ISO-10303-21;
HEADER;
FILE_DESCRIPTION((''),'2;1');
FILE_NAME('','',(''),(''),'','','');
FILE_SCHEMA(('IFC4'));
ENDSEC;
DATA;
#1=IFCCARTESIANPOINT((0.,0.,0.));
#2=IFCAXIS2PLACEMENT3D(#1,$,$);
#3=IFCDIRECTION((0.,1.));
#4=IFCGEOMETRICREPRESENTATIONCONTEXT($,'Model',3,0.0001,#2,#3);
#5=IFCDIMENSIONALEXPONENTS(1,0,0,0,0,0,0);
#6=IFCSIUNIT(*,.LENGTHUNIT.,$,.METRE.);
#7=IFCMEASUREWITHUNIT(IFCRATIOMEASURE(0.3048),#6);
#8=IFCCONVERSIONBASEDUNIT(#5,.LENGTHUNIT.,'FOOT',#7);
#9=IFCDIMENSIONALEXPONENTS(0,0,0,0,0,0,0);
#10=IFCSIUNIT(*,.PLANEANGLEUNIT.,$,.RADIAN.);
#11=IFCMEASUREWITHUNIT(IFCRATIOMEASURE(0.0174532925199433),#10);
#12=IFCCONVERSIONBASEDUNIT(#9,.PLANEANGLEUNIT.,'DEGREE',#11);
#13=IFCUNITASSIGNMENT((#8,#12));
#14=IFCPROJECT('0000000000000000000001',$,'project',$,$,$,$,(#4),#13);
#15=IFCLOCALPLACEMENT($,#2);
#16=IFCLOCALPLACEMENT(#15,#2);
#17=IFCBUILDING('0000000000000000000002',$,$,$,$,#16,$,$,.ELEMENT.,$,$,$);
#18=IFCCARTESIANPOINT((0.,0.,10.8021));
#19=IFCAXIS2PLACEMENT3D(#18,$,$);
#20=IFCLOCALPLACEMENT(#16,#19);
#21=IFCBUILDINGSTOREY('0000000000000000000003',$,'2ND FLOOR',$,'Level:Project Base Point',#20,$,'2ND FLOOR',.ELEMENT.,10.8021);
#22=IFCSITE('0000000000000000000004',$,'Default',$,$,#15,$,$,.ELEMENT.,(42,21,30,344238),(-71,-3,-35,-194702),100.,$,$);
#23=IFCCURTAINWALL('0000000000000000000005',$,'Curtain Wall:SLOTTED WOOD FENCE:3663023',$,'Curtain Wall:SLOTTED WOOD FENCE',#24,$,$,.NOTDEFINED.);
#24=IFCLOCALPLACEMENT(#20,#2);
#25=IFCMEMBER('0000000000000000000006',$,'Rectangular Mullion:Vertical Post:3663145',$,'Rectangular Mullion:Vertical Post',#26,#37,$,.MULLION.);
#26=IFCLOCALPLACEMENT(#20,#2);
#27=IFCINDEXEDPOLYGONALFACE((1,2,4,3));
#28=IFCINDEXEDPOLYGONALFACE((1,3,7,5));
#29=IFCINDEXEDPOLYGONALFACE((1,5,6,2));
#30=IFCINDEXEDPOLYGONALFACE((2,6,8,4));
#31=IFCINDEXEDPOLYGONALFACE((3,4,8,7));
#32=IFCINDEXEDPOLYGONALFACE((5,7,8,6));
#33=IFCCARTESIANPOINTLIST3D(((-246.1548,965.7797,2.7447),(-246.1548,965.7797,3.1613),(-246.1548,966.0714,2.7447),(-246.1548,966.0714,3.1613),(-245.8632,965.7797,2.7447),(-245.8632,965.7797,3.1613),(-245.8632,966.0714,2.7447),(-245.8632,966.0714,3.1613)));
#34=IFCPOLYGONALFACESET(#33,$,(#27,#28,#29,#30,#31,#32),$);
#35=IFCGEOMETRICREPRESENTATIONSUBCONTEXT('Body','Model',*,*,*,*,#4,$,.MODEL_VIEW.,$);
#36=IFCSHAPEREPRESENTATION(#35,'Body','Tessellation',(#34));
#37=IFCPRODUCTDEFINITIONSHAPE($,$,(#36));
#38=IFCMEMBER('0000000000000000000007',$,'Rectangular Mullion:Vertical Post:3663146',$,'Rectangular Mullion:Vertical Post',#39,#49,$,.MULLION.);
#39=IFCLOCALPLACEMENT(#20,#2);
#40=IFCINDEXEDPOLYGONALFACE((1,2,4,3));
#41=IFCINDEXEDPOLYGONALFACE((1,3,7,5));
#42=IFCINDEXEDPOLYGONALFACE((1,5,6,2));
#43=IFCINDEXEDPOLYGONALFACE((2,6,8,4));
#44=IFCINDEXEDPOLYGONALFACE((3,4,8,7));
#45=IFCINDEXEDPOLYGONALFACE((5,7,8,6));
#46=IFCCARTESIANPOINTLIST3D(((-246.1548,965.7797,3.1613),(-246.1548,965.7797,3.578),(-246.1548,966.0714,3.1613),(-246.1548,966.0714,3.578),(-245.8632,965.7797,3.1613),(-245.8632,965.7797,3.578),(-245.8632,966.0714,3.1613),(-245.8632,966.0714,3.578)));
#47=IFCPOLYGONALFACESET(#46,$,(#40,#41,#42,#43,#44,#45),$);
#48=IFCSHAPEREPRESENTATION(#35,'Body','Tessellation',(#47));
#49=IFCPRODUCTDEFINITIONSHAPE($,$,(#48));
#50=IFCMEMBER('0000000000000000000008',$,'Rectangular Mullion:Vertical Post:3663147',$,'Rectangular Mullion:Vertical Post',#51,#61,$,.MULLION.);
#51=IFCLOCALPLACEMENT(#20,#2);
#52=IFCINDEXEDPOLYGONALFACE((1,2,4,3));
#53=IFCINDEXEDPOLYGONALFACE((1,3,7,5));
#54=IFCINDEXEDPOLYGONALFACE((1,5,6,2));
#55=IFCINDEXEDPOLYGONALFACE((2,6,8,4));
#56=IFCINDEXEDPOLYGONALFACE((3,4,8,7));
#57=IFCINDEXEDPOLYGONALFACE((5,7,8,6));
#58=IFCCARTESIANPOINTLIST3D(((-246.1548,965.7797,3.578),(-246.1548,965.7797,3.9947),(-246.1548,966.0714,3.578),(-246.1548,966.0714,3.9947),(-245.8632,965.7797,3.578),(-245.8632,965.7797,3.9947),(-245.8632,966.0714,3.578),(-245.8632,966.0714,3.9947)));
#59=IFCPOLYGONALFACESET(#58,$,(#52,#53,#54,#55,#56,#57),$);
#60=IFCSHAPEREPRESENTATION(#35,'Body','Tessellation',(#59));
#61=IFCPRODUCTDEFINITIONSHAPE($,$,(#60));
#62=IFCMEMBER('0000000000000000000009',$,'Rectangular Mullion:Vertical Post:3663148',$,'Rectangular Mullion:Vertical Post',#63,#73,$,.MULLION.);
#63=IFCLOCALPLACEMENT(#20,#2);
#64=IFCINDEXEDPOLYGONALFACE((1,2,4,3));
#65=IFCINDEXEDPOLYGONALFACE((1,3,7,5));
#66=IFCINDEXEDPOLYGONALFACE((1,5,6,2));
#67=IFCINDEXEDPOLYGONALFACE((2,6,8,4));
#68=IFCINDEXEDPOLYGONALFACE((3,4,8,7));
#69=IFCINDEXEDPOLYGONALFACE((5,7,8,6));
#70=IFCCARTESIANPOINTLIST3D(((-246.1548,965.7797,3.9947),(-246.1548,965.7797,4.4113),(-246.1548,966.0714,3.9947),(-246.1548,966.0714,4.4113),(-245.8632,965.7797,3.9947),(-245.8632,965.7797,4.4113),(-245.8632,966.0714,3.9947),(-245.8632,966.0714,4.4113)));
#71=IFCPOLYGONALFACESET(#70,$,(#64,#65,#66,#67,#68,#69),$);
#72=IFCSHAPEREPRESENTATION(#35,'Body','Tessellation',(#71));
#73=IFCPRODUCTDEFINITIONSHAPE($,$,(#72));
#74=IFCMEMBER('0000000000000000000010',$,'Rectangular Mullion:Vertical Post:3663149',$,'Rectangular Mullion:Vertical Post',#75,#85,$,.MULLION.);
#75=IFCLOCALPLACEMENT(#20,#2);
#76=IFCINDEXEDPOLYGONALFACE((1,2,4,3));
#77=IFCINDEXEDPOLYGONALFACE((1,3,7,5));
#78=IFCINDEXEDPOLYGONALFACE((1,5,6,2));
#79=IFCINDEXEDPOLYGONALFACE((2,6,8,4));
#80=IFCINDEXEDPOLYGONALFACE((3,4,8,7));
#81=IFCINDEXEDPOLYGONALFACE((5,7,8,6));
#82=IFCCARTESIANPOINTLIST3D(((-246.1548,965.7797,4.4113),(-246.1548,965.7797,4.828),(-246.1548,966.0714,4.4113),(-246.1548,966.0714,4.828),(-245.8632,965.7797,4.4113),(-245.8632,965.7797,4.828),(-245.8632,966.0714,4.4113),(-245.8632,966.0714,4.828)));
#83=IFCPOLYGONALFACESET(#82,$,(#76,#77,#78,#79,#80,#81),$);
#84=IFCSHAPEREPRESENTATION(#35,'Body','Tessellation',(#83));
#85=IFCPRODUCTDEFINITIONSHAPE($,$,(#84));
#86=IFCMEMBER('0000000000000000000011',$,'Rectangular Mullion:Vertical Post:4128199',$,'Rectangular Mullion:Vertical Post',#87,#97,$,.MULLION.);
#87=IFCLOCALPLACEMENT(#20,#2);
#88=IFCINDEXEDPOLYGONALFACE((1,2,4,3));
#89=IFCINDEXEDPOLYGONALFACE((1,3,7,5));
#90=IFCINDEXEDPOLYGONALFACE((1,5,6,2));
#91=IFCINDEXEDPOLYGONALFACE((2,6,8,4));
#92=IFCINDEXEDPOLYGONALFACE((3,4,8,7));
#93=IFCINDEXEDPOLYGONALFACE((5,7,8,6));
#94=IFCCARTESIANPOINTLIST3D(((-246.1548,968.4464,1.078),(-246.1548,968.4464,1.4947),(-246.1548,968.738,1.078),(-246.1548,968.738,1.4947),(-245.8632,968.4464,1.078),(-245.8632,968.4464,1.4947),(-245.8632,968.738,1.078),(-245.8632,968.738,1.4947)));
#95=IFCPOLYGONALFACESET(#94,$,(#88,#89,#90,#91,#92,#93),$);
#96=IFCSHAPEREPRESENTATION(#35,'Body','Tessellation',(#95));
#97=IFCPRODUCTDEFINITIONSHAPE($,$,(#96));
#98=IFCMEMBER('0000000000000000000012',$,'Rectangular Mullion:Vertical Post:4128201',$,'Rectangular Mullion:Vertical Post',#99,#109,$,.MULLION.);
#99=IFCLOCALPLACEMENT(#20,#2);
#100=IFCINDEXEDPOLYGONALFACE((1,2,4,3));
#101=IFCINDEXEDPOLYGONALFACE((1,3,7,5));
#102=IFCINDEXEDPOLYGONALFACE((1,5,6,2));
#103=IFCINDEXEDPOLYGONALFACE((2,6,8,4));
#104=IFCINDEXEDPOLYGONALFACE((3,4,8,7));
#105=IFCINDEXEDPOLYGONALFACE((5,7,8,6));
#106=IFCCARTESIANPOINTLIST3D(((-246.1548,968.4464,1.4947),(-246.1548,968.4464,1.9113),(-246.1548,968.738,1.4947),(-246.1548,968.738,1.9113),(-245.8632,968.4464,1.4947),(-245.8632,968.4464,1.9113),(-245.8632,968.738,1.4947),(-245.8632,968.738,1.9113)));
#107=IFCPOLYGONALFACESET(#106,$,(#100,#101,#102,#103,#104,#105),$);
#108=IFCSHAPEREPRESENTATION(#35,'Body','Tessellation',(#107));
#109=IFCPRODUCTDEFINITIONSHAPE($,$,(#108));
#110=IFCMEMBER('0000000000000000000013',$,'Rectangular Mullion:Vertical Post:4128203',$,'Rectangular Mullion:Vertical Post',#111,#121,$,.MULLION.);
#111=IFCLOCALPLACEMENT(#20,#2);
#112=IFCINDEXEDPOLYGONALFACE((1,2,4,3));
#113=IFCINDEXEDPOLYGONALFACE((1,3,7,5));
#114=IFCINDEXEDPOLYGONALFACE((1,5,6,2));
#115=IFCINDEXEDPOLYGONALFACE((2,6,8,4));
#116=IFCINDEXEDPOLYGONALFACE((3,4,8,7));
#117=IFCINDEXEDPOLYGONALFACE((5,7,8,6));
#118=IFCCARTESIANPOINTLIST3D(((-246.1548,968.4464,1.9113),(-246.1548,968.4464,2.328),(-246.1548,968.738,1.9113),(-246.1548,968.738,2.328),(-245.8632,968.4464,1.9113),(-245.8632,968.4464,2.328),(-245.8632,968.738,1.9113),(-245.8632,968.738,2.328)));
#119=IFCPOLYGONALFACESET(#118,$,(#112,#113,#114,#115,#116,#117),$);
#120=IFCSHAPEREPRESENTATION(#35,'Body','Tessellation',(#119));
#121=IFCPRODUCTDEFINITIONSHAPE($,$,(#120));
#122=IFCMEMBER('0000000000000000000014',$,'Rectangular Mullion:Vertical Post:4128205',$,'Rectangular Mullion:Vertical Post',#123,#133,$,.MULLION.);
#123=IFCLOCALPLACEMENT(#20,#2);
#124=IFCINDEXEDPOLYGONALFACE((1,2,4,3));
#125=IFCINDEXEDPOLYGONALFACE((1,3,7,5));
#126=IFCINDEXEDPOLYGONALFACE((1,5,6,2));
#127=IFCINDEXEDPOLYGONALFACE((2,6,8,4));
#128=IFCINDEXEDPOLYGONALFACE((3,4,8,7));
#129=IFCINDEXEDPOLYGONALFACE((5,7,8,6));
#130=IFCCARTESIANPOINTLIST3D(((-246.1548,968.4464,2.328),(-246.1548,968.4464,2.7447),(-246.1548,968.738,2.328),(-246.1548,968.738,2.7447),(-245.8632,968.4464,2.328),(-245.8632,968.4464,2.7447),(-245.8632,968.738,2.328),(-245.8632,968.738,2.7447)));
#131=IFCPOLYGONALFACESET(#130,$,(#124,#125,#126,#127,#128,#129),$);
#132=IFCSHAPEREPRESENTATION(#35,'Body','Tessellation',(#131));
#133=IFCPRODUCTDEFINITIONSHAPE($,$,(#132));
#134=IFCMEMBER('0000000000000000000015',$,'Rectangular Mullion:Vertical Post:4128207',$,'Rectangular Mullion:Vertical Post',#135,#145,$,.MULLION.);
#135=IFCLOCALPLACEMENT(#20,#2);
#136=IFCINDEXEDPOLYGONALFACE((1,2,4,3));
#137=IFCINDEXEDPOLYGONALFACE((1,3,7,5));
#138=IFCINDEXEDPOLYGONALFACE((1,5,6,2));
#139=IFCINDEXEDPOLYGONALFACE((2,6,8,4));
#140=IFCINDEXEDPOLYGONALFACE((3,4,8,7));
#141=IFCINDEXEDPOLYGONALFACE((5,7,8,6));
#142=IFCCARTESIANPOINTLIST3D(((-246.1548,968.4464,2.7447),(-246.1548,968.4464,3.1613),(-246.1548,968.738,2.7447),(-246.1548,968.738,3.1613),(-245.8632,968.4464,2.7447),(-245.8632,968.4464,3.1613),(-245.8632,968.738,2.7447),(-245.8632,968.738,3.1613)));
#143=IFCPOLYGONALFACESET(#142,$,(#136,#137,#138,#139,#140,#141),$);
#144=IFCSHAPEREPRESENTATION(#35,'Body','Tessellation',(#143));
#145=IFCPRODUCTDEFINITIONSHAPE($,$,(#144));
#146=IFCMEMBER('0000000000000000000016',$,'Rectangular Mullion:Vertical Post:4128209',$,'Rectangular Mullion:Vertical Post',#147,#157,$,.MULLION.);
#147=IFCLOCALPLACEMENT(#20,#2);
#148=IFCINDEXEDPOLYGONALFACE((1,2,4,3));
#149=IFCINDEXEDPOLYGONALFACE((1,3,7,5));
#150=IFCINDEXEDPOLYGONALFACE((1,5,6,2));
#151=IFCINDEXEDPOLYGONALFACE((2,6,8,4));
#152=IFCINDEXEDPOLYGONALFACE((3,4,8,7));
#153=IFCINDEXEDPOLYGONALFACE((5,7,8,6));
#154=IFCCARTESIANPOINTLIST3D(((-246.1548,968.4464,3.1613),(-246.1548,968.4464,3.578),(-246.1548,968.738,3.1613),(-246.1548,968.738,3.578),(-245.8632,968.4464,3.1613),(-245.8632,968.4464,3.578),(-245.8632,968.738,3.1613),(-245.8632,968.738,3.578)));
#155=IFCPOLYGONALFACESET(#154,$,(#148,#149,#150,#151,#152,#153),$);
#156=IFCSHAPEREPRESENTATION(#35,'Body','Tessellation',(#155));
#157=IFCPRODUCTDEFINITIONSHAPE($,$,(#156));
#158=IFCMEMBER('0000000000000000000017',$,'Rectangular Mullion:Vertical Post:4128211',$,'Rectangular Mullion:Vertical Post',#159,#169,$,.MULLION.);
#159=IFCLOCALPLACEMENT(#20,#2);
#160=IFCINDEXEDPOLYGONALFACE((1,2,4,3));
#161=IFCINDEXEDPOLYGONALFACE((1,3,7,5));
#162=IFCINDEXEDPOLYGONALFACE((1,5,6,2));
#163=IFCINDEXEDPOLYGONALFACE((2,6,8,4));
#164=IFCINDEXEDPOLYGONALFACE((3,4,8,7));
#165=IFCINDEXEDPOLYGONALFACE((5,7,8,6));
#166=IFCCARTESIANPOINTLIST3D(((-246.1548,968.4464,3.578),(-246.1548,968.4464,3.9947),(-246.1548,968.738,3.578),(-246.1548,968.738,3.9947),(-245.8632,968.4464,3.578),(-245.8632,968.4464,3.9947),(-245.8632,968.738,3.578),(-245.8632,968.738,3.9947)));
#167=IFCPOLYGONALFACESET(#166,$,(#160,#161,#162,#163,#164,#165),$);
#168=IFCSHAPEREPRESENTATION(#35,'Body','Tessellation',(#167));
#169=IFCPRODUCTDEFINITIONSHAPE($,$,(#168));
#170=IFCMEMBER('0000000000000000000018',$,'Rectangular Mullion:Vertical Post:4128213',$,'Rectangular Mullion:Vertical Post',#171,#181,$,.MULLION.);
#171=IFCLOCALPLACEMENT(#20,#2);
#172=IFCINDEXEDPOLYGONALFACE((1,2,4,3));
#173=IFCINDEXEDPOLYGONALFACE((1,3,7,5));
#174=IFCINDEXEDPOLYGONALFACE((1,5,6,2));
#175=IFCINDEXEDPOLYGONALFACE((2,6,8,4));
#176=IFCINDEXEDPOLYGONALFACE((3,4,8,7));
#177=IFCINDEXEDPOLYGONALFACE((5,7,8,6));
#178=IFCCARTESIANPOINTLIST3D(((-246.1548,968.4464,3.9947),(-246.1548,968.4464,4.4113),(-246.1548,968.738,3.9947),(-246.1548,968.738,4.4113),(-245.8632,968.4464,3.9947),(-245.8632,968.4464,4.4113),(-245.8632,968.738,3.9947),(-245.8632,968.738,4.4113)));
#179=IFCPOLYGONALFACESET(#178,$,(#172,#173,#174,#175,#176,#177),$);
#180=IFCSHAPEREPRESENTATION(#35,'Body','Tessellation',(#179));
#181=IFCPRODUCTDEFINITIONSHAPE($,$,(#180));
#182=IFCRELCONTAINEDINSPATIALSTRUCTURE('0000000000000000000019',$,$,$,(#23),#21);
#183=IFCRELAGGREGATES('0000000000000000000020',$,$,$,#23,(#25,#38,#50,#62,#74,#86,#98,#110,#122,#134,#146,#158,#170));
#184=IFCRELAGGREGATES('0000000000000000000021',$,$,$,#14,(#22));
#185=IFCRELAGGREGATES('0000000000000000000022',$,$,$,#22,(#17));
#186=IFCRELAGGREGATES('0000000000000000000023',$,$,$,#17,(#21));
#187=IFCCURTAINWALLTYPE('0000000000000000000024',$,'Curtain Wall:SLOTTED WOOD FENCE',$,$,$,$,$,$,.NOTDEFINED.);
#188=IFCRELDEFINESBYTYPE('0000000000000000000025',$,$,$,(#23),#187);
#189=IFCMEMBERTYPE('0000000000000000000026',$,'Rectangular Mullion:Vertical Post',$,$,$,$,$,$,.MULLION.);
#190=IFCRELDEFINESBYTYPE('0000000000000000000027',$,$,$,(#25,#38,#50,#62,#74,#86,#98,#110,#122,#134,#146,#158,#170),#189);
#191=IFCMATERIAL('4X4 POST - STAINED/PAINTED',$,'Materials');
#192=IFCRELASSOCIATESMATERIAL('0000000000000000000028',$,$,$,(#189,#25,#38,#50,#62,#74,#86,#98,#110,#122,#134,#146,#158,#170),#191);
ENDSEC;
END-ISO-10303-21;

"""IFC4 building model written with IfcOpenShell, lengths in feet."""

from ifc_helpers import new_model, entity, si_unit, converted_unit, direction, frame, origin, origin_2d_with_axis, place, context, subcontext, project, spatial, rectangle, extrude, source, transform, mapped, material, material_profile, profile_set, profile_usage, type_object, type_shapes, element, aggregate, save


model = new_model("IFC4")

# Units and contexts
model_context = context("Model", 3, precision=0.0001, world=origin(), true_north=direction((0.0, 1.0)))
body_context = subcontext(model_context, "Body", "Model", "MODEL_VIEW")
ifc_project = project(units=[converted_unit("LENGTHUNIT", "FOOT", entity("IfcRatioMeasure", 0.3048), si_unit("LENGTHUNIT", "METRE"), dimensions=[1, 0, 0, 0, 0, 0, 0]), converted_unit("PLANEANGLEUNIT", "DEGREE", entity("IfcRatioMeasure", 0.0174532925199433), si_unit("PLANEANGLEUNIT", "RADIAN"), dimensions=[0, 0, 0, 0, 0, 0, 0])], contexts=[model_context])

# Site, building, storey
site_placement = place(None, origin())
site = spatial("IfcSite", under=ifc_project, at=site_placement, Name="Default", CompositionType="ELEMENT", RefLatitude=(42, 21, 30, 344238), RefLongitude=(-71, -3, -35, -194702), RefElevation=100.0)
building_placement = place(site_placement, origin())
building = spatial("IfcBuilding", under=site, at=building_placement, CompositionType="ELEMENT")
storey_placement = place(building_placement, frame((0.0, 0.0, 10.8021)))
storey = spatial("IfcBuildingStorey", under=building, at=storey_placement, Name="2ND FLOOR", ObjectType="Level:Project Base Point", LongName="2ND FLOOR", CompositionType="ELEMENT", Elevation=10.8021)

# Curtain wall, members
curtain_wall_type_1 = type_object("IfcCurtainWallType", Name="Curtain Wall:SLOTTED WOOD FENCE", PredefinedType="NOTDEFINED")
curtain_wall_1_placement = place(storey_placement, frame((0.0, 0.0, -10.8021)))
curtain_wall_1 = element("IfcCurtainWall", 1, at=curtain_wall_1_placement, inside=storey, type_object=curtain_wall_type_1, Name="Curtain Wall:SLOTTED WOOD FENCE:3663023", ObjectType="Curtain Wall:SLOTTED WOOD FENCE", PredefinedType="NOTDEFINED")
ifc_material_1 = material(Name="4X4 POST - STAINED/PAINTED", Category="Materials")
ifc_material_profile_1 = material_profile(ifc_material_1, rectangle(XDim=0.2917, YDim=0.2917, at=origin_2d_with_axis()), Name="Vertical Post")
ifc_profile_set_1 = profile_set([ifc_material_profile_1], Name="Vertical Post")
member_type_1 = type_object("IfcMemberType", Name="Rectangular Mullion:Vertical Post", PredefinedType="MULLION", material=ifc_profile_set_1)
shared_shape_1 = source(origin(), body_context, "Body", "SweptSolid", [
    extrude(rectangle(XDim=0.2917, YDim=0.2917, at=origin_2d_with_axis()), frame((0.0, 0.2083, -0.4167), z_axis=(0.0, 0.0, 1.0), x_axis=(0.0, -1.0, 0.0)), (0.0, 0.0, 1.0), 0.4167),
])
type_shapes(member_type_1, [shared_shape_1])
ifc_profile_usage_1 = profile_usage(ifc_profile_set_1)
member_1_placement = place(storey_placement, frame((-245.8007, 965.9255, 2.7447), z_axis=(0.0, 0.0, -1.0), x_axis=(0.0, -1.0, 0.0)))
member_1 = element("IfcMember", 2, at=member_1_placement, type_object=member_type_1, material=ifc_profile_usage_1, Name="Rectangular Mullion:Vertical Post:3663145", ObjectType="Rectangular Mullion:Vertical Post", PredefinedType="MULLION", context=body_context, shape_type="MappedRepresentation", body=[
    mapped(shared_shape_1, transform((0.0, 0.0, 0.0), scale=1.0)),
])
ifc_profile_usage_2 = profile_usage(ifc_profile_set_1)
member_2_placement = place(storey_placement, frame((-245.8007, 965.9255, 3.1613), z_axis=(0.0, 0.0, -1.0), x_axis=(0.0, -1.0, 0.0)))
member_2 = element("IfcMember", 3, at=member_2_placement, type_object=member_type_1, material=ifc_profile_usage_2, Name="Rectangular Mullion:Vertical Post:3663146", ObjectType="Rectangular Mullion:Vertical Post", PredefinedType="MULLION", context=body_context, shape_type="MappedRepresentation", body=[
    mapped(shared_shape_1, transform((0.0, 0.0, 0.0), scale=1.0)),
])
ifc_profile_usage_3 = profile_usage(ifc_profile_set_1)
member_3_placement = place(storey_placement, frame((-245.8007, 965.9255, 3.578), z_axis=(0.0, 0.0, -1.0), x_axis=(0.0, -1.0, 0.0)))
member_3 = element("IfcMember", 4, at=member_3_placement, type_object=member_type_1, material=ifc_profile_usage_3, Name="Rectangular Mullion:Vertical Post:3663147", ObjectType="Rectangular Mullion:Vertical Post", PredefinedType="MULLION", context=body_context, shape_type="MappedRepresentation", body=[
    mapped(shared_shape_1, transform((0.0, 0.0, 0.0), scale=1.0)),
])
ifc_profile_usage_4 = profile_usage(ifc_profile_set_1)
member_4_placement = place(storey_placement, frame((-245.8007, 965.9255, 3.9947), z_axis=(0.0, 0.0, -1.0), x_axis=(0.0, -1.0, 0.0)))
member_4 = element("IfcMember", 5, at=member_4_placement, type_object=member_type_1, material=ifc_profile_usage_4, Name="Rectangular Mullion:Vertical Post:3663148", ObjectType="Rectangular Mullion:Vertical Post", PredefinedType="MULLION", context=body_context, shape_type="MappedRepresentation", body=[
    mapped(shared_shape_1, transform((0.0, 0.0, 0.0), scale=1.0)),
])
ifc_profile_usage_5 = profile_usage(ifc_profile_set_1)
member_5_placement = place(storey_placement, frame((-245.8007, 965.9255, 4.4113), z_axis=(0.0, 0.0, -1.0), x_axis=(0.0, -1.0, 0.0)))
member_5 = element("IfcMember", 6, at=member_5_placement, type_object=member_type_1, material=ifc_profile_usage_5, Name="Rectangular Mullion:Vertical Post:3663149", ObjectType="Rectangular Mullion:Vertical Post", PredefinedType="MULLION", context=body_context, shape_type="MappedRepresentation", body=[
    mapped(shared_shape_1, transform((0.0, 0.0, 0.0), scale=1.0)),
])
ifc_profile_usage_6 = profile_usage(ifc_profile_set_1)
member_6_placement = place(storey_placement, frame((-245.8007, 968.5922, 1.078), z_axis=(0.0, 0.0, -1.0), x_axis=(0.0, -1.0, 0.0)))
member_6 = element("IfcMember", 7, at=member_6_placement, type_object=member_type_1, material=ifc_profile_usage_6, Name="Rectangular Mullion:Vertical Post:4128199", ObjectType="Rectangular Mullion:Vertical Post", PredefinedType="MULLION", context=body_context, shape_type="MappedRepresentation", body=[
    mapped(shared_shape_1, transform((0.0, 0.0, 0.0), scale=1.0)),
])
ifc_profile_usage_7 = profile_usage(ifc_profile_set_1)
member_7_placement = place(storey_placement, frame((-245.8007, 968.5922, 1.4947), z_axis=(0.0, 0.0, -1.0), x_axis=(0.0, -1.0, 0.0)))
member_7 = element("IfcMember", 8, at=member_7_placement, type_object=member_type_1, material=ifc_profile_usage_7, Name="Rectangular Mullion:Vertical Post:4128201", ObjectType="Rectangular Mullion:Vertical Post", PredefinedType="MULLION", context=body_context, shape_type="MappedRepresentation", body=[
    mapped(shared_shape_1, transform((0.0, 0.0, 0.0), scale=1.0)),
])
ifc_profile_usage_8 = profile_usage(ifc_profile_set_1)
member_8_placement = place(storey_placement, frame((-245.8007, 968.5922, 1.9113), z_axis=(0.0, 0.0, -1.0), x_axis=(0.0, -1.0, 0.0)))
member_8 = element("IfcMember", 9, at=member_8_placement, type_object=member_type_1, material=ifc_profile_usage_8, Name="Rectangular Mullion:Vertical Post:4128203", ObjectType="Rectangular Mullion:Vertical Post", PredefinedType="MULLION", context=body_context, shape_type="MappedRepresentation", body=[
    mapped(shared_shape_1, transform((0.0, 0.0, 0.0), scale=1.0)),
])
ifc_profile_usage_9 = profile_usage(ifc_profile_set_1)
member_9_placement = place(storey_placement, frame((-245.8007, 968.5922, 2.328), z_axis=(0.0, 0.0, -1.0), x_axis=(0.0, -1.0, 0.0)))
member_9 = element("IfcMember", 10, at=member_9_placement, type_object=member_type_1, material=ifc_profile_usage_9, Name="Rectangular Mullion:Vertical Post:4128205", ObjectType="Rectangular Mullion:Vertical Post", PredefinedType="MULLION", context=body_context, shape_type="MappedRepresentation", body=[
    mapped(shared_shape_1, transform((0.0, 0.0, 0.0), scale=1.0)),
])
ifc_profile_usage_10 = profile_usage(ifc_profile_set_1)
member_10_placement = place(storey_placement, frame((-245.8007, 968.5922, 2.7447), z_axis=(0.0, 0.0, -1.0), x_axis=(0.0, -1.0, 0.0)))
member_10 = element("IfcMember", 11, at=member_10_placement, type_object=member_type_1, material=ifc_profile_usage_10, Name="Rectangular Mullion:Vertical Post:4128207", ObjectType="Rectangular Mullion:Vertical Post", PredefinedType="MULLION", context=body_context, shape_type="MappedRepresentation", body=[
    mapped(shared_shape_1, transform((0.0, 0.0, 0.0), scale=1.0)),
])
ifc_profile_usage_11 = profile_usage(ifc_profile_set_1)
member_11_placement = place(storey_placement, frame((-245.8007, 968.5922, 3.1613), z_axis=(0.0, 0.0, -1.0), x_axis=(0.0, -1.0, 0.0)))
member_11 = element("IfcMember", 12, at=member_11_placement, type_object=member_type_1, material=ifc_profile_usage_11, Name="Rectangular Mullion:Vertical Post:4128209", ObjectType="Rectangular Mullion:Vertical Post", PredefinedType="MULLION", context=body_context, shape_type="MappedRepresentation", body=[
    mapped(shared_shape_1, transform((0.0, 0.0, 0.0), scale=1.0)),
])
ifc_profile_usage_12 = profile_usage(ifc_profile_set_1)
member_12_placement = place(storey_placement, frame((-245.8007, 968.5922, 3.578), z_axis=(0.0, 0.0, -1.0), x_axis=(0.0, -1.0, 0.0)))
member_12 = element("IfcMember", 13, at=member_12_placement, type_object=member_type_1, material=ifc_profile_usage_12, Name="Rectangular Mullion:Vertical Post:4128211", ObjectType="Rectangular Mullion:Vertical Post", PredefinedType="MULLION", context=body_context, shape_type="MappedRepresentation", body=[
    mapped(shared_shape_1, transform((0.0, 0.0, 0.0), scale=1.0)),
])
ifc_profile_usage_13 = profile_usage(ifc_profile_set_1)
member_13_placement = place(storey_placement, frame((-245.8007, 968.5922, 3.9947), z_axis=(0.0, 0.0, -1.0), x_axis=(0.0, -1.0, 0.0)))
member_13 = element("IfcMember", 14, at=member_13_placement, type_object=member_type_1, material=ifc_profile_usage_13, Name="Rectangular Mullion:Vertical Post:4128213", ObjectType="Rectangular Mullion:Vertical Post", PredefinedType="MULLION", context=body_context, shape_type="MappedRepresentation", body=[
    mapped(shared_shape_1, transform((0.0, 0.0, 0.0), scale=1.0)),
])
aggregate(curtain_wall_1, [member_1, member_2, member_3, member_4, member_5, member_6, member_7, member_8, member_9, member_10, member_11, member_12, member_13])

save(model, "model.ifc")
